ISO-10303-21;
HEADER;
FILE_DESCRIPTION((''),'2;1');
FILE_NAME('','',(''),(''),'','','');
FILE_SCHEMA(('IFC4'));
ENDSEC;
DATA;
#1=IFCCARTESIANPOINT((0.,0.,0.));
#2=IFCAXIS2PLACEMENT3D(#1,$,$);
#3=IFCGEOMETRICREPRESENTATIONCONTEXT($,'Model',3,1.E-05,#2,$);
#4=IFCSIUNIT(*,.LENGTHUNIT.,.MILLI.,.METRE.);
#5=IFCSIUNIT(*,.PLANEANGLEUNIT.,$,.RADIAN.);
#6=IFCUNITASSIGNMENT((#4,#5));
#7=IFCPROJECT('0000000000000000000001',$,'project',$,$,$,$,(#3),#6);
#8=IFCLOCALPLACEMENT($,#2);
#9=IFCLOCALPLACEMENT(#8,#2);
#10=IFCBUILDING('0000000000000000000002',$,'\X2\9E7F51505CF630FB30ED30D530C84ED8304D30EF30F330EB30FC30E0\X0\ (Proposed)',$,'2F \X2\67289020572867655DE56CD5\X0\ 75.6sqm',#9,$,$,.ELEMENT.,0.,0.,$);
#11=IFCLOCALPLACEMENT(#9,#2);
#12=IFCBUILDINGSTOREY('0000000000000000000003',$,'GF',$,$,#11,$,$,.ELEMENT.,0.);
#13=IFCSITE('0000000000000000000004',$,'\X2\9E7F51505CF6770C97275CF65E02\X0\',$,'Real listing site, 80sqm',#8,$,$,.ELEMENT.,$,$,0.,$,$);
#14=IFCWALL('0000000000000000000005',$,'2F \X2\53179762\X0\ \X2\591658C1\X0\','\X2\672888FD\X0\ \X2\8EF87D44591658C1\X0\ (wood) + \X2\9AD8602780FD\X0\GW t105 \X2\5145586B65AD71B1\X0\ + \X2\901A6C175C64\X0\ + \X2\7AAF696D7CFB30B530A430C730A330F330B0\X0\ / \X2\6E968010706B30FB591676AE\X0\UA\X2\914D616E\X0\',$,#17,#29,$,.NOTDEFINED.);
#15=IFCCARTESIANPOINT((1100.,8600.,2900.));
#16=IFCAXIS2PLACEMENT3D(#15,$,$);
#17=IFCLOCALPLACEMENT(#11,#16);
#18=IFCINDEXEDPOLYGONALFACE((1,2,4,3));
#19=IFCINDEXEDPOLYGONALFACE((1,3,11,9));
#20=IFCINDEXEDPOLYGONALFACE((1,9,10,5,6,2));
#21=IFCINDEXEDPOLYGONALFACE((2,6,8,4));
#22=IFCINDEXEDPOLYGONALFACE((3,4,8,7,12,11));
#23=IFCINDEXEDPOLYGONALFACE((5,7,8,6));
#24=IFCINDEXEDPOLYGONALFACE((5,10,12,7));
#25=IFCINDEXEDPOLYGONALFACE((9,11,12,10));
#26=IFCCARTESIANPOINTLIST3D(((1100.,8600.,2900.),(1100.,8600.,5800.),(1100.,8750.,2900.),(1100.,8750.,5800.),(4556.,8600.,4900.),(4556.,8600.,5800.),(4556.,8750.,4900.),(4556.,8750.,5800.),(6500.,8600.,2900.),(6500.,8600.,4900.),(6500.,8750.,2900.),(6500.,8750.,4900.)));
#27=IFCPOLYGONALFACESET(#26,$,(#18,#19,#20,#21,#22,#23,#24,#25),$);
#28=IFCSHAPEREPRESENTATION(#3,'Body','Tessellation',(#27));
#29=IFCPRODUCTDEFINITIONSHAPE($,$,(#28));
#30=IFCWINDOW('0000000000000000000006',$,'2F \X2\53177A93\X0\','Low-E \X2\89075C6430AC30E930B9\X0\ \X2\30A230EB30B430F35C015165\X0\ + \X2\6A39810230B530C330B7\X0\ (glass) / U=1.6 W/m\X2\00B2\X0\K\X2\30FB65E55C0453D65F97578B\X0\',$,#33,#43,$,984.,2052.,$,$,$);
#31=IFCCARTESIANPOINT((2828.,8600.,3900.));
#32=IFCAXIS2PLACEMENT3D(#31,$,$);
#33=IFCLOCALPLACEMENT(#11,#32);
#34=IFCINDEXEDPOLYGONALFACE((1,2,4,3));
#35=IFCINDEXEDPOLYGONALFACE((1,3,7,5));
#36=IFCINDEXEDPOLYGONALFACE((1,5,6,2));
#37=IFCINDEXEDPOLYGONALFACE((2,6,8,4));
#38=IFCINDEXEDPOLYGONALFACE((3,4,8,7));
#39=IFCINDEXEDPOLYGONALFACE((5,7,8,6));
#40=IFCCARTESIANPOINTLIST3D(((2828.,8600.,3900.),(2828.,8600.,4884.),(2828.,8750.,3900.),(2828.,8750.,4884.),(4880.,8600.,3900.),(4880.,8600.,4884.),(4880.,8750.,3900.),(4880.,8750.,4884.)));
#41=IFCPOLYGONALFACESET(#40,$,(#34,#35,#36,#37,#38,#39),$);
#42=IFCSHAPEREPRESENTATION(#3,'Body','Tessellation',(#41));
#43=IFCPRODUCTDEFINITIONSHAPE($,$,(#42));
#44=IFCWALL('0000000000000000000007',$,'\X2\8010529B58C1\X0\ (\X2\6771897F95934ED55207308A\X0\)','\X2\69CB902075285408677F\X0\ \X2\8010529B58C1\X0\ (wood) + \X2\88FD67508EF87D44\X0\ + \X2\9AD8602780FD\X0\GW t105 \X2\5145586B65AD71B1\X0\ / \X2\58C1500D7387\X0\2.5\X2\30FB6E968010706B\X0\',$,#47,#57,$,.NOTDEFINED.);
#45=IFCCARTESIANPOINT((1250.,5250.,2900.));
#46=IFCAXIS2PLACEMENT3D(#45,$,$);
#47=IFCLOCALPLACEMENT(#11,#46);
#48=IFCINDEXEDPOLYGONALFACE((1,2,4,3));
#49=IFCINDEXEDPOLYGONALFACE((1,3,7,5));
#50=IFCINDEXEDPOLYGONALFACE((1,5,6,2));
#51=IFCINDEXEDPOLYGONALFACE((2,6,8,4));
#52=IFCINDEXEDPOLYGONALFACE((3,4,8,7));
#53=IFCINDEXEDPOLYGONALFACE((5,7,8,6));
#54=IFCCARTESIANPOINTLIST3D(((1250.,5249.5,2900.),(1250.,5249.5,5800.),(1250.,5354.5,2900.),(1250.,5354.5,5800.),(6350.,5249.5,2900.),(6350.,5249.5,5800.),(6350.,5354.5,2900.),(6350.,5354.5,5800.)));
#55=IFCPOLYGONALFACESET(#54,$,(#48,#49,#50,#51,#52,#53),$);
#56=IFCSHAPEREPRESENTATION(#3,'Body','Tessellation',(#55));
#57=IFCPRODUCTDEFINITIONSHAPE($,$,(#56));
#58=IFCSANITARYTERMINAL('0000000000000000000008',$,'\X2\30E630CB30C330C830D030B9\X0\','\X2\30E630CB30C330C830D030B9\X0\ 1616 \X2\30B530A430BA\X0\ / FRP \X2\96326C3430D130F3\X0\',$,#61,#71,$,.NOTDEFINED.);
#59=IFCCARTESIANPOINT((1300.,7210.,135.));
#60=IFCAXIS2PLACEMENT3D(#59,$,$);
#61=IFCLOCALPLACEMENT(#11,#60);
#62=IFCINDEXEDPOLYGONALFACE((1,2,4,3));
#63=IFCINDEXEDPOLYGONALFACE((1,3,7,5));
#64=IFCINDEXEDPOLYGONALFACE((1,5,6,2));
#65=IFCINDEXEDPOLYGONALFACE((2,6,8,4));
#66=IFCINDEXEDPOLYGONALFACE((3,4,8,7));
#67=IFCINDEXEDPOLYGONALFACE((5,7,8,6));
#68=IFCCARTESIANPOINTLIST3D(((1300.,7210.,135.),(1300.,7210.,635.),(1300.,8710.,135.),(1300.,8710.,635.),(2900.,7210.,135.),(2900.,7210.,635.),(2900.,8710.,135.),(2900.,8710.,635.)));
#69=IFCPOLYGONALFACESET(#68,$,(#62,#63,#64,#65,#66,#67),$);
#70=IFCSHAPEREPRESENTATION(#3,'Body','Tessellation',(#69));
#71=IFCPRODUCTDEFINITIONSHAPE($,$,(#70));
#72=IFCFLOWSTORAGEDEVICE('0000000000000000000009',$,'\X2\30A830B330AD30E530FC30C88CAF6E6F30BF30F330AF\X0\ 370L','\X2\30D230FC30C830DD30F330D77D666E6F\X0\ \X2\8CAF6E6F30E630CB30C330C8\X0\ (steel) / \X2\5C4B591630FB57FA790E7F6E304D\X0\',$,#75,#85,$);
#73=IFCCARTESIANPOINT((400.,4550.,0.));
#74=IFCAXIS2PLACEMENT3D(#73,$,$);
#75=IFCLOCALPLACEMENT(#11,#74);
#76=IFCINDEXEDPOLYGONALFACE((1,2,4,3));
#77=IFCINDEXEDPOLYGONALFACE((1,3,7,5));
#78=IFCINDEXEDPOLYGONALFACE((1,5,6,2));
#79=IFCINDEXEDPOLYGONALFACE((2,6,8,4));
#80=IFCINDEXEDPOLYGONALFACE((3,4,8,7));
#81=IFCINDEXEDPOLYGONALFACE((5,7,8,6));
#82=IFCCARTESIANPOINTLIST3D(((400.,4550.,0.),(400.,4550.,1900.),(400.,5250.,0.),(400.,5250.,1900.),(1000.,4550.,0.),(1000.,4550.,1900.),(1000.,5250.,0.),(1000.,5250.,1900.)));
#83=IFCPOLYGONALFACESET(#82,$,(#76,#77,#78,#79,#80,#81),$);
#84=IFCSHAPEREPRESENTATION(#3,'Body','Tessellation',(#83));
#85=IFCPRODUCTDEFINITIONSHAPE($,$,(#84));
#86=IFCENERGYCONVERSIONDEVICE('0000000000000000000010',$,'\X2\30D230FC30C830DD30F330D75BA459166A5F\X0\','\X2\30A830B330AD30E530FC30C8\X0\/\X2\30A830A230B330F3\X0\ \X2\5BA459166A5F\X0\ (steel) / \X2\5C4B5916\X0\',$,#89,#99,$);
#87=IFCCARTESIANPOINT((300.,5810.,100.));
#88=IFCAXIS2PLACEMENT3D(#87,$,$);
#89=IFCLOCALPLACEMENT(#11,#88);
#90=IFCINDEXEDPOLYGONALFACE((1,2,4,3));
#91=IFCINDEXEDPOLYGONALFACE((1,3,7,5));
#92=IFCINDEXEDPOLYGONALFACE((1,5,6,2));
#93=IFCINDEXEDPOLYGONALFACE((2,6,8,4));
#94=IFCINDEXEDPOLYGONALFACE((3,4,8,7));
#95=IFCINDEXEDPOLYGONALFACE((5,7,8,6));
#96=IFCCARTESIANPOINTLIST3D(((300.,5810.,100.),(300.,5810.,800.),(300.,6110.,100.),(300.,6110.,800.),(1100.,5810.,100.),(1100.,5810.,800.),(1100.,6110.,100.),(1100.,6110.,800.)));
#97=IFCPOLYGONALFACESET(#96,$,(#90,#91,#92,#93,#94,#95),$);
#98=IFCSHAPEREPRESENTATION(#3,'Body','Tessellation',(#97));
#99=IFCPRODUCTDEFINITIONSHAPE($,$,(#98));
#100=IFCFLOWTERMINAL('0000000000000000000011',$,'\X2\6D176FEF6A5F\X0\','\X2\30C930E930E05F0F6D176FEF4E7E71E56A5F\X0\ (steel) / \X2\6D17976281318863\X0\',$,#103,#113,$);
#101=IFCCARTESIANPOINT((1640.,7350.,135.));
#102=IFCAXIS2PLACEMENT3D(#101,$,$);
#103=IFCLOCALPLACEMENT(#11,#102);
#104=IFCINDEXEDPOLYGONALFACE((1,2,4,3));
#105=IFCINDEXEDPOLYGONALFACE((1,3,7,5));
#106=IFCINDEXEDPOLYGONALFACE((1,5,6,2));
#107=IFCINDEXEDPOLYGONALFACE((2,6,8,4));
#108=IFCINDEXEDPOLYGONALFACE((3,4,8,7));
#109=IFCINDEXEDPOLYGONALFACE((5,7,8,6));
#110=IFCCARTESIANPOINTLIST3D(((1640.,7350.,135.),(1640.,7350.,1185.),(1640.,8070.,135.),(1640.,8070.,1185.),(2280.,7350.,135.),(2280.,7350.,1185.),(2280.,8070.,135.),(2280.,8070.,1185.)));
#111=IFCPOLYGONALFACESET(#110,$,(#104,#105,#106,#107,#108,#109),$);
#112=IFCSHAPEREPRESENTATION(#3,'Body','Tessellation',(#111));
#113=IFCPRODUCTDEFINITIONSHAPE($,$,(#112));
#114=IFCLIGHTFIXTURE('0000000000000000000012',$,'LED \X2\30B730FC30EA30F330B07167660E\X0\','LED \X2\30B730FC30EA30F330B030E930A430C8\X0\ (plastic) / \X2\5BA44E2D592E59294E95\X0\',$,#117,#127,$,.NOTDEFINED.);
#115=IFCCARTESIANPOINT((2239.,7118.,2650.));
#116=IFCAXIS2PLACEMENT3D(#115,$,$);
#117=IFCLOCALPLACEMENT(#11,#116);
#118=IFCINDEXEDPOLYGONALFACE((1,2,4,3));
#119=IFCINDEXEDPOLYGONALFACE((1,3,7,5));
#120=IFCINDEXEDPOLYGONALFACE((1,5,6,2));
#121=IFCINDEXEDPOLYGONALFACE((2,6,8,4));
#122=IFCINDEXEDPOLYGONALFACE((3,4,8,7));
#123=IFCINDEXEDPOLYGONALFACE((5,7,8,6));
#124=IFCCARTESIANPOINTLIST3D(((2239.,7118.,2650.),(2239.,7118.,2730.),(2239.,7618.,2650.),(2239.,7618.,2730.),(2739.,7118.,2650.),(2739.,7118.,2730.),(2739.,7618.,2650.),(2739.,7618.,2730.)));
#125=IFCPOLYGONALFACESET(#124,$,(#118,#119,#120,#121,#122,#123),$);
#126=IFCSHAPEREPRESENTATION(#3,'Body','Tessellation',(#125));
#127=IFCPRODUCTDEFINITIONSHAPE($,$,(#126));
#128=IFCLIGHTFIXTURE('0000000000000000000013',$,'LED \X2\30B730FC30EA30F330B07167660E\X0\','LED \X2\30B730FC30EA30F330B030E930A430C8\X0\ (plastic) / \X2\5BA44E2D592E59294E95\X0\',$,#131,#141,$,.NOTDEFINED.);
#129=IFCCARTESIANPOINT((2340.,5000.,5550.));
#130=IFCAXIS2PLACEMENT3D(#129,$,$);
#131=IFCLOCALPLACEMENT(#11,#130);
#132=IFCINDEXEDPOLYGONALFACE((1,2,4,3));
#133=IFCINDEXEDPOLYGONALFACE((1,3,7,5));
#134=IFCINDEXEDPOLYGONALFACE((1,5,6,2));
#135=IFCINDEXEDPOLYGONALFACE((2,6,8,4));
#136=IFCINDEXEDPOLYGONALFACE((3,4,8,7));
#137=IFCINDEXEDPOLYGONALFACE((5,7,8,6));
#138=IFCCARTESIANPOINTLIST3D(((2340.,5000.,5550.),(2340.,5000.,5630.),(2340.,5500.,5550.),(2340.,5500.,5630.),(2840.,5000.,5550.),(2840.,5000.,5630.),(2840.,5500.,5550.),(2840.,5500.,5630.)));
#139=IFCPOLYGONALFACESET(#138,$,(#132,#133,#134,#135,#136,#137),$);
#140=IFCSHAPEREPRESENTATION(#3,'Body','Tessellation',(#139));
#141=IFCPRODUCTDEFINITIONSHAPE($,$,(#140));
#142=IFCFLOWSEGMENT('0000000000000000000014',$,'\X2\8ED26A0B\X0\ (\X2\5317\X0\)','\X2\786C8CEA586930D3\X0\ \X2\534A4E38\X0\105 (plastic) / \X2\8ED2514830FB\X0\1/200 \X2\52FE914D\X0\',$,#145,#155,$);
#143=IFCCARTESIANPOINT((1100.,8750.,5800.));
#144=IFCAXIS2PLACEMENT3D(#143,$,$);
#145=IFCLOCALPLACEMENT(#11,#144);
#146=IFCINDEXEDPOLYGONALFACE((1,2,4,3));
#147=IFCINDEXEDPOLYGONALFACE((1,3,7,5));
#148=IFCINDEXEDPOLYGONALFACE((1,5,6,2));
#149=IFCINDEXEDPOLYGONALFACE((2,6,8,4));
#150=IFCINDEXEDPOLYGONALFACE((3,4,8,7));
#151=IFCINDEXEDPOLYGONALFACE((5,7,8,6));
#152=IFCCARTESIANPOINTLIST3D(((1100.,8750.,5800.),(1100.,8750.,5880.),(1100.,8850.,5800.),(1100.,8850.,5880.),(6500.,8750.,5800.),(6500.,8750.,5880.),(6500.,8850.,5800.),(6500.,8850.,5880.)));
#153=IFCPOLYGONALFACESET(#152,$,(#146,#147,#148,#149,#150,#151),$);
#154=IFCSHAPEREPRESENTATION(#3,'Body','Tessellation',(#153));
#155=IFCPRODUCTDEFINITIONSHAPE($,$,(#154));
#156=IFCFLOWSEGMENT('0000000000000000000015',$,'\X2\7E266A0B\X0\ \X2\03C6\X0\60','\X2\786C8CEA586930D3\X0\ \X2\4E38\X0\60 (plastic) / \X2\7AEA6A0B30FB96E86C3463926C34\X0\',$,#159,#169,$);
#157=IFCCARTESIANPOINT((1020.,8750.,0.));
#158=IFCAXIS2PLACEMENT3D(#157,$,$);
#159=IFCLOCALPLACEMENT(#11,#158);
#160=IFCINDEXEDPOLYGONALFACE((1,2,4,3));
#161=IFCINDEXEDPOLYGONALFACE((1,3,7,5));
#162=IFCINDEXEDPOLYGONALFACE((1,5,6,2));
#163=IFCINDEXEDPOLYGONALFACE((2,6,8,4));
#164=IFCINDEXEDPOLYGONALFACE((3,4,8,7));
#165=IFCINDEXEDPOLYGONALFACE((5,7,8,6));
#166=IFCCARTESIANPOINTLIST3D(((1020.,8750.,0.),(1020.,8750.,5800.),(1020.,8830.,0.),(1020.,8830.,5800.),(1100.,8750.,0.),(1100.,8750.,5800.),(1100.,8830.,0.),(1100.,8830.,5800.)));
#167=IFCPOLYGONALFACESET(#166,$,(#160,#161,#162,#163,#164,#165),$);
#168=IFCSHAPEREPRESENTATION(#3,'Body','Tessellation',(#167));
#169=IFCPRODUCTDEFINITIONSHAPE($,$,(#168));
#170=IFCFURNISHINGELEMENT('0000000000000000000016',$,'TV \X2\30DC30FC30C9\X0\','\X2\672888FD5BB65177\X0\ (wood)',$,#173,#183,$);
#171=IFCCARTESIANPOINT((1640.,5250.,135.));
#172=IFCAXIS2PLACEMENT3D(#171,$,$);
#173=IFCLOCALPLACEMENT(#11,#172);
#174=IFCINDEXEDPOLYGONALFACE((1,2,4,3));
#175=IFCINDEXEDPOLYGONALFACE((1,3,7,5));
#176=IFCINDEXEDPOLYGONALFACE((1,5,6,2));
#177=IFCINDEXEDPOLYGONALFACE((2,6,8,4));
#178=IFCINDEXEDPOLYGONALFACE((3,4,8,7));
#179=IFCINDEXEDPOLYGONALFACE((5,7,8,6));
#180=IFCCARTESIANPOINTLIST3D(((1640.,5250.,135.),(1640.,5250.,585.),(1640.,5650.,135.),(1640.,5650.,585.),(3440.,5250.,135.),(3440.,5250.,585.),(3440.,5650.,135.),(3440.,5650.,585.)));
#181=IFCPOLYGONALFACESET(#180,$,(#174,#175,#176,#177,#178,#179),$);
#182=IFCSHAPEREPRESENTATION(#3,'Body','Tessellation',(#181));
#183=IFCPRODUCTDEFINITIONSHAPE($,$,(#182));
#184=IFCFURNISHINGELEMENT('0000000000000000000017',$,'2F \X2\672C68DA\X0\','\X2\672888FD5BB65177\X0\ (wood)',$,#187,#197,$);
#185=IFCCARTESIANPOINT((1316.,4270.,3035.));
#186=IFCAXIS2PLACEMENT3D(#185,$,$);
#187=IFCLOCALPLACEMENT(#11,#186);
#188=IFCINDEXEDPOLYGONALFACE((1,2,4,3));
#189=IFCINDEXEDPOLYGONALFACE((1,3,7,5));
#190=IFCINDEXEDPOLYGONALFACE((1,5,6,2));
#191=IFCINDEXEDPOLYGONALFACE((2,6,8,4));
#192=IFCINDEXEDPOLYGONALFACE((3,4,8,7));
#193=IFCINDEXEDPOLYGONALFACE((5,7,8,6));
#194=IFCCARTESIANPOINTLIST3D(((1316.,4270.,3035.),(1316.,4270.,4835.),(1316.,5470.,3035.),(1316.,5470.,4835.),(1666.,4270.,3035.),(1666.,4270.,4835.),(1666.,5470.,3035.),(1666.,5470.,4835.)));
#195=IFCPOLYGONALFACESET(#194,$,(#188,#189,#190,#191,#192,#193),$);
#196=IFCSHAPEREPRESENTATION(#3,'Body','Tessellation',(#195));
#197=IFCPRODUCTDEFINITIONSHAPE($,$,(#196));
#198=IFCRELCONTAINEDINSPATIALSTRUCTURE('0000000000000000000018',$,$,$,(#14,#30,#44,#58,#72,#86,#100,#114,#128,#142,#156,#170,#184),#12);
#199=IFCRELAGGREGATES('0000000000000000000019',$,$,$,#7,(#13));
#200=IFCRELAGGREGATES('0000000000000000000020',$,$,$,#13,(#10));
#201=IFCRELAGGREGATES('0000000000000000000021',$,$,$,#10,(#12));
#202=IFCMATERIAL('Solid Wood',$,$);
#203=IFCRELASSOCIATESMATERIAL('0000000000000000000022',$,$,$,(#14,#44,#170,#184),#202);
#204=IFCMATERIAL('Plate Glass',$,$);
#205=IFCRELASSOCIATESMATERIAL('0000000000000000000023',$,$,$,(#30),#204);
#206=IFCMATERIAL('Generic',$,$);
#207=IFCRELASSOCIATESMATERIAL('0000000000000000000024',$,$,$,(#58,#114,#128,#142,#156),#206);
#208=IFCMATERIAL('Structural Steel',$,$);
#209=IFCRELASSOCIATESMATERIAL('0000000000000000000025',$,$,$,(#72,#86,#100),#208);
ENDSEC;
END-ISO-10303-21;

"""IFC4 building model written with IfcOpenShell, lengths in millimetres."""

from ifc_helpers import new_model, si_unit, frame, frame_2d, origin, place, context, project, spatial, rectangle, extrude, material, element, fill, save


model = new_model("IFC4")

# Units and contexts
model_context = context("Model", 3, precision=1e-05, world=origin())
ifc_project = project(units=[si_unit("LENGTHUNIT", "METRE", prefix="MILLI"), si_unit("PLANEANGLEUNIT", "RADIAN")], contexts=[model_context])

# Site, building, storey
site_placement = place(None, origin())
site = spatial("IfcSite", under=ifc_project, at=site_placement, Name="鹿児島県霧島市", ObjectType="Real listing site, 80sqm", CompositionType="ELEMENT", RefElevation=0.0)
building_placement = place(site_placement, origin())
building = spatial("IfcBuilding", under=site, at=building_placement, Name="鹿児島・ロフト付きワンルーム (Proposed)", ObjectType="2F 木造在来工法 75.6sqm", CompositionType="ELEMENT", ElevationOfRefHeight=0.0, ElevationOfTerrain=0.0)
storey_placement = place(building_placement, origin())
storey = spatial("IfcBuildingStorey", under=building, at=storey_placement, Name="GF", CompositionType="ELEMENT", Elevation=0.0)

# Shared definitions
ifc_material_1 = material(Name="Solid Wood")

# Shared definitions
ifc_material_2 = material(Name="Plate Glass")

# Wall, opening, window
wall_1_placement = place(storey_placement, frame((1100.0, 8600.0, 2900.0)))
wall_1 = element("IfcWall", 1, at=wall_1_placement, inside=storey, material=ifc_material_1, Name="2F 北面 外壁", Description="木製 軸組外壁 (wood) + 高性能GW t105 充填断熱 + 通気層 + 窯業系サイディング / 準耐火・外皮UA配慮", PredefinedType="NOTDEFINED", context=model_context, shape_type="SweptSolid", body=[
    extrude(rectangle(XDim=5400.0, YDim=150.0, at=frame_2d((2700.0, 75.0))), frame((1100.0, 8600.0, 2900.0)), (0.0, 0.0, 1.0), 2900.0),
])
opening_1_placement = place(storey_placement, frame((2828.0, 8600.0, 3900.0)))
opening_1 = element("IfcOpeningElement", 2, at=opening_1_placement, cuts=wall_1, PredefinedType="NOTDEFINED", context=model_context, shape_type="SweptSolid", body=[
    extrude(rectangle(XDim=2052.0, YDim=150.0, at=frame_2d((1026.0, 75.0))), frame((2828.0, 8600.0, 3900.0)), (0.0, 0.0, 1.0), 984.0),
])
window_1_placement = place(storey_placement, frame((2828.0, 8600.0, 3900.0)))
window_1 = element("IfcWindow", 3, at=window_1_placement, inside=storey, material=ifc_material_2, Name="2F 北窓", Description="Low-E 複層ガラス アルゴン封入 + 樹脂サッシ (glass) / U=1.6 W/m²K・日射取得型", OverallHeight=984.0, OverallWidth=2052.0, context=model_context, shape_type="SweptSolid", body=[
    extrude(rectangle(XDim=2052.0, YDim=150.0, at=frame_2d((1026.0, 75.0))), frame((2828.0, 8600.0, 3900.0)), (0.0, 0.0, 1.0), 984.0),
])
fill(opening_1, window_1)

# Wall
wall_2_placement = place(storey_placement, frame((1250.0, 5250.0, 2900.0)))
element("IfcWall", 4, at=wall_2_placement, inside=storey, material=ifc_material_1, Name="耐力壁 (東西間仕切り)", Description="構造用合板 耐力壁 (wood) + 製材軸組 + 高性能GW t105 充填断熱 / 壁倍率2.5・準耐火", PredefinedType="NOTDEFINED", context=model_context, shape_type="SweptSolid", body=[
    extrude(rectangle(XDim=5100.0, YDim=105.0, at=frame_2d((2550.0, 52.0))), frame((1250.0, 5250.0, 2900.0)), (0.0, 0.0, 1.0), 2900.0),
])

# Sanitary terminal
ifc_material_3 = material(Name="Generic")
sanitary_terminal_placement = place(storey_placement, frame((1300.0, 7210.0, 135.0)))
element("IfcSanitaryTerminal", 5, at=sanitary_terminal_placement, inside=storey, material=ifc_material_3, Name="ユニットバス", Description="ユニットバス 1616 サイズ / FRP 防水パン", PredefinedType="NOTDEFINED", context=model_context, shape_type="SweptSolid", body=[
    extrude(rectangle(XDim=1600.0, YDim=1500.0, at=frame_2d((800.0, 750.0))), frame((1300.0, 7210.0, 135.0)), (0.0, 0.0, 1.0), 500.0),
])

# Flow storage device
ifc_material_4 = material(Name="Structural Steel")
flow_storage_device_placement = place(storey_placement, frame((400.0, 4550.0, 0.0)))
element("IfcFlowStorageDevice", 6, at=flow_storage_device_placement, inside=storey, material=ifc_material_4, Name="エコキュート貯湯タンク 370L", Description="ヒートポンプ給湯 貯湯ユニット (steel) / 屋外・基礎置き", context=model_context, shape_type="SweptSolid", body=[
    extrude(rectangle(XDim=600.0, YDim=700.0, at=frame_2d((300.0, 350.0))), frame((400.0, 4550.0, 0.0)), (0.0, 0.0, 1.0), 1900.0),
])

# Energy conversion device
energy_conversion_device_placement = place(storey_placement, frame((300.0, 5810.0, 100.0)))
element("IfcEnergyConversionDevice", 7, at=energy_conversion_device_placement, inside=storey, material=ifc_material_4, Name="ヒートポンプ室外機", Description="エコキュート/エアコン 室外機 (steel) / 屋外", context=model_context, shape_type="SweptSolid", body=[
    extrude(rectangle(XDim=800.0, YDim=300.0, at=frame_2d((400.0, 150.0))), frame((300.0, 5810.0, 100.0)), (0.0, 0.0, 1.0), 700.0),
])

# Flow terminal
flow_terminal_placement = place(storey_placement, frame((1640.0, 7350.0, 135.0)))
element("IfcFlowTerminal", 8, at=flow_terminal_placement, inside=storey, material=ifc_material_4, Name="洗濯機", Description="ドラム式洗濯乾燥機 (steel) / 洗面脱衣", context=model_context, shape_type="SweptSolid", body=[
    extrude(rectangle(XDim=640.0, YDim=720.0, at=frame_2d((320.0, 360.0))), frame((1640.0, 7350.0, 135.0)), (0.0, 0.0, 1.0), 1050.0),
])

# Light fixtures
light_fixture_1_placement = place(storey_placement, frame((2239.0, 7118.0, 2650.0)))
element("IfcLightFixture", 9, at=light_fixture_1_placement, inside=storey, material=ifc_material_3, Name="LED シーリング照明", Description="LED シーリングライト (plastic) / 室中央天井", PredefinedType="NOTDEFINED", context=model_context, shape_type="SweptSolid", body=[
    extrude(rectangle(XDim=500.0, YDim=500.0, at=frame_2d((250.0, 250.0))), frame((2239.0, 7118.0, 2650.0)), (0.0, 0.0, 1.0), 80.0),
])
light_fixture_2_placement = place(storey_placement, frame((2340.0, 5000.0, 5550.0)))
element("IfcLightFixture", 10, at=light_fixture_2_placement, inside=storey, material=ifc_material_3, Name="LED シーリング照明", Description="LED シーリングライト (plastic) / 室中央天井", PredefinedType="NOTDEFINED", context=model_context, shape_type="SweptSolid", body=[
    extrude(rectangle(XDim=500.0, YDim=500.0, at=frame_2d((250.0, 250.0))), frame((2340.0, 5000.0, 5550.0)), (0.0, 0.0, 1.0), 80.0),
])

# Flow segments
flow_segment_1_placement = place(storey_placement, frame((1100.0, 8750.0, 5800.0)))
element("IfcFlowSegment", 11, at=flow_segment_1_placement, inside=storey, material=ifc_material_3, Name="軒樋 (北)", Description="硬質塩ビ 半丸105 (plastic) / 軒先・1/200 勾配", context=model_context, shape_type="SweptSolid", body=[
    extrude(rectangle(XDim=5400.0, YDim=100.0, at=frame_2d((2700.0, 50.0))), frame((1100.0, 8750.0, 5800.0)), (0.0, 0.0, 1.0), 80.0),
])
flow_segment_2_placement = place(storey_placement, frame((1020.0, 8750.0, 0.0)))
element("IfcFlowSegment", 12, at=flow_segment_2_placement, inside=storey, material=ifc_material_3, Name="縦樋 φ60", Description="硬質塩ビ 丸60 (plastic) / 竪樋・雨水排水", context=model_context, shape_type="SweptSolid", body=[
    extrude(rectangle(XDim=80.0, YDim=80.0, at=frame_2d((40.0, 40.0))), frame((1020.0, 8750.0, 0.0)), (0.0, 0.0, 1.0), 5800.0),
])

# Furnishing elements
furnishing_1_placement = place(storey_placement, frame((1640.0, 5250.0, 135.0)))
element("IfcFurnishingElement", 13, at=furnishing_1_placement, inside=storey, material=ifc_material_1, Name="TV ボード", Description="木製家具 (wood)", context=model_context, shape_type="SweptSolid", body=[
    extrude(rectangle(XDim=1800.0, YDim=400.0, at=frame_2d((900.0, 200.0))), frame((1640.0, 5250.0, 135.0)), (0.0, 0.0, 1.0), 450.0),
])
furnishing_2_placement = place(storey_placement, frame((1316.0, 4270.0, 3035.0)))
element("IfcFurnishingElement", 14, at=furnishing_2_placement, inside=storey, material=ifc_material_1, Name="2F 本棚", Description="木製家具 (wood)", context=model_context, shape_type="SweptSolid", body=[
    extrude(rectangle(XDim=350.0, YDim=1200.0, at=frame_2d((175.0, 600.0))), frame((1316.0, 4270.0, 3035.0)), (0.0, 0.0, 1.0), 1800.0),
])

save(model, "model.ifc")
